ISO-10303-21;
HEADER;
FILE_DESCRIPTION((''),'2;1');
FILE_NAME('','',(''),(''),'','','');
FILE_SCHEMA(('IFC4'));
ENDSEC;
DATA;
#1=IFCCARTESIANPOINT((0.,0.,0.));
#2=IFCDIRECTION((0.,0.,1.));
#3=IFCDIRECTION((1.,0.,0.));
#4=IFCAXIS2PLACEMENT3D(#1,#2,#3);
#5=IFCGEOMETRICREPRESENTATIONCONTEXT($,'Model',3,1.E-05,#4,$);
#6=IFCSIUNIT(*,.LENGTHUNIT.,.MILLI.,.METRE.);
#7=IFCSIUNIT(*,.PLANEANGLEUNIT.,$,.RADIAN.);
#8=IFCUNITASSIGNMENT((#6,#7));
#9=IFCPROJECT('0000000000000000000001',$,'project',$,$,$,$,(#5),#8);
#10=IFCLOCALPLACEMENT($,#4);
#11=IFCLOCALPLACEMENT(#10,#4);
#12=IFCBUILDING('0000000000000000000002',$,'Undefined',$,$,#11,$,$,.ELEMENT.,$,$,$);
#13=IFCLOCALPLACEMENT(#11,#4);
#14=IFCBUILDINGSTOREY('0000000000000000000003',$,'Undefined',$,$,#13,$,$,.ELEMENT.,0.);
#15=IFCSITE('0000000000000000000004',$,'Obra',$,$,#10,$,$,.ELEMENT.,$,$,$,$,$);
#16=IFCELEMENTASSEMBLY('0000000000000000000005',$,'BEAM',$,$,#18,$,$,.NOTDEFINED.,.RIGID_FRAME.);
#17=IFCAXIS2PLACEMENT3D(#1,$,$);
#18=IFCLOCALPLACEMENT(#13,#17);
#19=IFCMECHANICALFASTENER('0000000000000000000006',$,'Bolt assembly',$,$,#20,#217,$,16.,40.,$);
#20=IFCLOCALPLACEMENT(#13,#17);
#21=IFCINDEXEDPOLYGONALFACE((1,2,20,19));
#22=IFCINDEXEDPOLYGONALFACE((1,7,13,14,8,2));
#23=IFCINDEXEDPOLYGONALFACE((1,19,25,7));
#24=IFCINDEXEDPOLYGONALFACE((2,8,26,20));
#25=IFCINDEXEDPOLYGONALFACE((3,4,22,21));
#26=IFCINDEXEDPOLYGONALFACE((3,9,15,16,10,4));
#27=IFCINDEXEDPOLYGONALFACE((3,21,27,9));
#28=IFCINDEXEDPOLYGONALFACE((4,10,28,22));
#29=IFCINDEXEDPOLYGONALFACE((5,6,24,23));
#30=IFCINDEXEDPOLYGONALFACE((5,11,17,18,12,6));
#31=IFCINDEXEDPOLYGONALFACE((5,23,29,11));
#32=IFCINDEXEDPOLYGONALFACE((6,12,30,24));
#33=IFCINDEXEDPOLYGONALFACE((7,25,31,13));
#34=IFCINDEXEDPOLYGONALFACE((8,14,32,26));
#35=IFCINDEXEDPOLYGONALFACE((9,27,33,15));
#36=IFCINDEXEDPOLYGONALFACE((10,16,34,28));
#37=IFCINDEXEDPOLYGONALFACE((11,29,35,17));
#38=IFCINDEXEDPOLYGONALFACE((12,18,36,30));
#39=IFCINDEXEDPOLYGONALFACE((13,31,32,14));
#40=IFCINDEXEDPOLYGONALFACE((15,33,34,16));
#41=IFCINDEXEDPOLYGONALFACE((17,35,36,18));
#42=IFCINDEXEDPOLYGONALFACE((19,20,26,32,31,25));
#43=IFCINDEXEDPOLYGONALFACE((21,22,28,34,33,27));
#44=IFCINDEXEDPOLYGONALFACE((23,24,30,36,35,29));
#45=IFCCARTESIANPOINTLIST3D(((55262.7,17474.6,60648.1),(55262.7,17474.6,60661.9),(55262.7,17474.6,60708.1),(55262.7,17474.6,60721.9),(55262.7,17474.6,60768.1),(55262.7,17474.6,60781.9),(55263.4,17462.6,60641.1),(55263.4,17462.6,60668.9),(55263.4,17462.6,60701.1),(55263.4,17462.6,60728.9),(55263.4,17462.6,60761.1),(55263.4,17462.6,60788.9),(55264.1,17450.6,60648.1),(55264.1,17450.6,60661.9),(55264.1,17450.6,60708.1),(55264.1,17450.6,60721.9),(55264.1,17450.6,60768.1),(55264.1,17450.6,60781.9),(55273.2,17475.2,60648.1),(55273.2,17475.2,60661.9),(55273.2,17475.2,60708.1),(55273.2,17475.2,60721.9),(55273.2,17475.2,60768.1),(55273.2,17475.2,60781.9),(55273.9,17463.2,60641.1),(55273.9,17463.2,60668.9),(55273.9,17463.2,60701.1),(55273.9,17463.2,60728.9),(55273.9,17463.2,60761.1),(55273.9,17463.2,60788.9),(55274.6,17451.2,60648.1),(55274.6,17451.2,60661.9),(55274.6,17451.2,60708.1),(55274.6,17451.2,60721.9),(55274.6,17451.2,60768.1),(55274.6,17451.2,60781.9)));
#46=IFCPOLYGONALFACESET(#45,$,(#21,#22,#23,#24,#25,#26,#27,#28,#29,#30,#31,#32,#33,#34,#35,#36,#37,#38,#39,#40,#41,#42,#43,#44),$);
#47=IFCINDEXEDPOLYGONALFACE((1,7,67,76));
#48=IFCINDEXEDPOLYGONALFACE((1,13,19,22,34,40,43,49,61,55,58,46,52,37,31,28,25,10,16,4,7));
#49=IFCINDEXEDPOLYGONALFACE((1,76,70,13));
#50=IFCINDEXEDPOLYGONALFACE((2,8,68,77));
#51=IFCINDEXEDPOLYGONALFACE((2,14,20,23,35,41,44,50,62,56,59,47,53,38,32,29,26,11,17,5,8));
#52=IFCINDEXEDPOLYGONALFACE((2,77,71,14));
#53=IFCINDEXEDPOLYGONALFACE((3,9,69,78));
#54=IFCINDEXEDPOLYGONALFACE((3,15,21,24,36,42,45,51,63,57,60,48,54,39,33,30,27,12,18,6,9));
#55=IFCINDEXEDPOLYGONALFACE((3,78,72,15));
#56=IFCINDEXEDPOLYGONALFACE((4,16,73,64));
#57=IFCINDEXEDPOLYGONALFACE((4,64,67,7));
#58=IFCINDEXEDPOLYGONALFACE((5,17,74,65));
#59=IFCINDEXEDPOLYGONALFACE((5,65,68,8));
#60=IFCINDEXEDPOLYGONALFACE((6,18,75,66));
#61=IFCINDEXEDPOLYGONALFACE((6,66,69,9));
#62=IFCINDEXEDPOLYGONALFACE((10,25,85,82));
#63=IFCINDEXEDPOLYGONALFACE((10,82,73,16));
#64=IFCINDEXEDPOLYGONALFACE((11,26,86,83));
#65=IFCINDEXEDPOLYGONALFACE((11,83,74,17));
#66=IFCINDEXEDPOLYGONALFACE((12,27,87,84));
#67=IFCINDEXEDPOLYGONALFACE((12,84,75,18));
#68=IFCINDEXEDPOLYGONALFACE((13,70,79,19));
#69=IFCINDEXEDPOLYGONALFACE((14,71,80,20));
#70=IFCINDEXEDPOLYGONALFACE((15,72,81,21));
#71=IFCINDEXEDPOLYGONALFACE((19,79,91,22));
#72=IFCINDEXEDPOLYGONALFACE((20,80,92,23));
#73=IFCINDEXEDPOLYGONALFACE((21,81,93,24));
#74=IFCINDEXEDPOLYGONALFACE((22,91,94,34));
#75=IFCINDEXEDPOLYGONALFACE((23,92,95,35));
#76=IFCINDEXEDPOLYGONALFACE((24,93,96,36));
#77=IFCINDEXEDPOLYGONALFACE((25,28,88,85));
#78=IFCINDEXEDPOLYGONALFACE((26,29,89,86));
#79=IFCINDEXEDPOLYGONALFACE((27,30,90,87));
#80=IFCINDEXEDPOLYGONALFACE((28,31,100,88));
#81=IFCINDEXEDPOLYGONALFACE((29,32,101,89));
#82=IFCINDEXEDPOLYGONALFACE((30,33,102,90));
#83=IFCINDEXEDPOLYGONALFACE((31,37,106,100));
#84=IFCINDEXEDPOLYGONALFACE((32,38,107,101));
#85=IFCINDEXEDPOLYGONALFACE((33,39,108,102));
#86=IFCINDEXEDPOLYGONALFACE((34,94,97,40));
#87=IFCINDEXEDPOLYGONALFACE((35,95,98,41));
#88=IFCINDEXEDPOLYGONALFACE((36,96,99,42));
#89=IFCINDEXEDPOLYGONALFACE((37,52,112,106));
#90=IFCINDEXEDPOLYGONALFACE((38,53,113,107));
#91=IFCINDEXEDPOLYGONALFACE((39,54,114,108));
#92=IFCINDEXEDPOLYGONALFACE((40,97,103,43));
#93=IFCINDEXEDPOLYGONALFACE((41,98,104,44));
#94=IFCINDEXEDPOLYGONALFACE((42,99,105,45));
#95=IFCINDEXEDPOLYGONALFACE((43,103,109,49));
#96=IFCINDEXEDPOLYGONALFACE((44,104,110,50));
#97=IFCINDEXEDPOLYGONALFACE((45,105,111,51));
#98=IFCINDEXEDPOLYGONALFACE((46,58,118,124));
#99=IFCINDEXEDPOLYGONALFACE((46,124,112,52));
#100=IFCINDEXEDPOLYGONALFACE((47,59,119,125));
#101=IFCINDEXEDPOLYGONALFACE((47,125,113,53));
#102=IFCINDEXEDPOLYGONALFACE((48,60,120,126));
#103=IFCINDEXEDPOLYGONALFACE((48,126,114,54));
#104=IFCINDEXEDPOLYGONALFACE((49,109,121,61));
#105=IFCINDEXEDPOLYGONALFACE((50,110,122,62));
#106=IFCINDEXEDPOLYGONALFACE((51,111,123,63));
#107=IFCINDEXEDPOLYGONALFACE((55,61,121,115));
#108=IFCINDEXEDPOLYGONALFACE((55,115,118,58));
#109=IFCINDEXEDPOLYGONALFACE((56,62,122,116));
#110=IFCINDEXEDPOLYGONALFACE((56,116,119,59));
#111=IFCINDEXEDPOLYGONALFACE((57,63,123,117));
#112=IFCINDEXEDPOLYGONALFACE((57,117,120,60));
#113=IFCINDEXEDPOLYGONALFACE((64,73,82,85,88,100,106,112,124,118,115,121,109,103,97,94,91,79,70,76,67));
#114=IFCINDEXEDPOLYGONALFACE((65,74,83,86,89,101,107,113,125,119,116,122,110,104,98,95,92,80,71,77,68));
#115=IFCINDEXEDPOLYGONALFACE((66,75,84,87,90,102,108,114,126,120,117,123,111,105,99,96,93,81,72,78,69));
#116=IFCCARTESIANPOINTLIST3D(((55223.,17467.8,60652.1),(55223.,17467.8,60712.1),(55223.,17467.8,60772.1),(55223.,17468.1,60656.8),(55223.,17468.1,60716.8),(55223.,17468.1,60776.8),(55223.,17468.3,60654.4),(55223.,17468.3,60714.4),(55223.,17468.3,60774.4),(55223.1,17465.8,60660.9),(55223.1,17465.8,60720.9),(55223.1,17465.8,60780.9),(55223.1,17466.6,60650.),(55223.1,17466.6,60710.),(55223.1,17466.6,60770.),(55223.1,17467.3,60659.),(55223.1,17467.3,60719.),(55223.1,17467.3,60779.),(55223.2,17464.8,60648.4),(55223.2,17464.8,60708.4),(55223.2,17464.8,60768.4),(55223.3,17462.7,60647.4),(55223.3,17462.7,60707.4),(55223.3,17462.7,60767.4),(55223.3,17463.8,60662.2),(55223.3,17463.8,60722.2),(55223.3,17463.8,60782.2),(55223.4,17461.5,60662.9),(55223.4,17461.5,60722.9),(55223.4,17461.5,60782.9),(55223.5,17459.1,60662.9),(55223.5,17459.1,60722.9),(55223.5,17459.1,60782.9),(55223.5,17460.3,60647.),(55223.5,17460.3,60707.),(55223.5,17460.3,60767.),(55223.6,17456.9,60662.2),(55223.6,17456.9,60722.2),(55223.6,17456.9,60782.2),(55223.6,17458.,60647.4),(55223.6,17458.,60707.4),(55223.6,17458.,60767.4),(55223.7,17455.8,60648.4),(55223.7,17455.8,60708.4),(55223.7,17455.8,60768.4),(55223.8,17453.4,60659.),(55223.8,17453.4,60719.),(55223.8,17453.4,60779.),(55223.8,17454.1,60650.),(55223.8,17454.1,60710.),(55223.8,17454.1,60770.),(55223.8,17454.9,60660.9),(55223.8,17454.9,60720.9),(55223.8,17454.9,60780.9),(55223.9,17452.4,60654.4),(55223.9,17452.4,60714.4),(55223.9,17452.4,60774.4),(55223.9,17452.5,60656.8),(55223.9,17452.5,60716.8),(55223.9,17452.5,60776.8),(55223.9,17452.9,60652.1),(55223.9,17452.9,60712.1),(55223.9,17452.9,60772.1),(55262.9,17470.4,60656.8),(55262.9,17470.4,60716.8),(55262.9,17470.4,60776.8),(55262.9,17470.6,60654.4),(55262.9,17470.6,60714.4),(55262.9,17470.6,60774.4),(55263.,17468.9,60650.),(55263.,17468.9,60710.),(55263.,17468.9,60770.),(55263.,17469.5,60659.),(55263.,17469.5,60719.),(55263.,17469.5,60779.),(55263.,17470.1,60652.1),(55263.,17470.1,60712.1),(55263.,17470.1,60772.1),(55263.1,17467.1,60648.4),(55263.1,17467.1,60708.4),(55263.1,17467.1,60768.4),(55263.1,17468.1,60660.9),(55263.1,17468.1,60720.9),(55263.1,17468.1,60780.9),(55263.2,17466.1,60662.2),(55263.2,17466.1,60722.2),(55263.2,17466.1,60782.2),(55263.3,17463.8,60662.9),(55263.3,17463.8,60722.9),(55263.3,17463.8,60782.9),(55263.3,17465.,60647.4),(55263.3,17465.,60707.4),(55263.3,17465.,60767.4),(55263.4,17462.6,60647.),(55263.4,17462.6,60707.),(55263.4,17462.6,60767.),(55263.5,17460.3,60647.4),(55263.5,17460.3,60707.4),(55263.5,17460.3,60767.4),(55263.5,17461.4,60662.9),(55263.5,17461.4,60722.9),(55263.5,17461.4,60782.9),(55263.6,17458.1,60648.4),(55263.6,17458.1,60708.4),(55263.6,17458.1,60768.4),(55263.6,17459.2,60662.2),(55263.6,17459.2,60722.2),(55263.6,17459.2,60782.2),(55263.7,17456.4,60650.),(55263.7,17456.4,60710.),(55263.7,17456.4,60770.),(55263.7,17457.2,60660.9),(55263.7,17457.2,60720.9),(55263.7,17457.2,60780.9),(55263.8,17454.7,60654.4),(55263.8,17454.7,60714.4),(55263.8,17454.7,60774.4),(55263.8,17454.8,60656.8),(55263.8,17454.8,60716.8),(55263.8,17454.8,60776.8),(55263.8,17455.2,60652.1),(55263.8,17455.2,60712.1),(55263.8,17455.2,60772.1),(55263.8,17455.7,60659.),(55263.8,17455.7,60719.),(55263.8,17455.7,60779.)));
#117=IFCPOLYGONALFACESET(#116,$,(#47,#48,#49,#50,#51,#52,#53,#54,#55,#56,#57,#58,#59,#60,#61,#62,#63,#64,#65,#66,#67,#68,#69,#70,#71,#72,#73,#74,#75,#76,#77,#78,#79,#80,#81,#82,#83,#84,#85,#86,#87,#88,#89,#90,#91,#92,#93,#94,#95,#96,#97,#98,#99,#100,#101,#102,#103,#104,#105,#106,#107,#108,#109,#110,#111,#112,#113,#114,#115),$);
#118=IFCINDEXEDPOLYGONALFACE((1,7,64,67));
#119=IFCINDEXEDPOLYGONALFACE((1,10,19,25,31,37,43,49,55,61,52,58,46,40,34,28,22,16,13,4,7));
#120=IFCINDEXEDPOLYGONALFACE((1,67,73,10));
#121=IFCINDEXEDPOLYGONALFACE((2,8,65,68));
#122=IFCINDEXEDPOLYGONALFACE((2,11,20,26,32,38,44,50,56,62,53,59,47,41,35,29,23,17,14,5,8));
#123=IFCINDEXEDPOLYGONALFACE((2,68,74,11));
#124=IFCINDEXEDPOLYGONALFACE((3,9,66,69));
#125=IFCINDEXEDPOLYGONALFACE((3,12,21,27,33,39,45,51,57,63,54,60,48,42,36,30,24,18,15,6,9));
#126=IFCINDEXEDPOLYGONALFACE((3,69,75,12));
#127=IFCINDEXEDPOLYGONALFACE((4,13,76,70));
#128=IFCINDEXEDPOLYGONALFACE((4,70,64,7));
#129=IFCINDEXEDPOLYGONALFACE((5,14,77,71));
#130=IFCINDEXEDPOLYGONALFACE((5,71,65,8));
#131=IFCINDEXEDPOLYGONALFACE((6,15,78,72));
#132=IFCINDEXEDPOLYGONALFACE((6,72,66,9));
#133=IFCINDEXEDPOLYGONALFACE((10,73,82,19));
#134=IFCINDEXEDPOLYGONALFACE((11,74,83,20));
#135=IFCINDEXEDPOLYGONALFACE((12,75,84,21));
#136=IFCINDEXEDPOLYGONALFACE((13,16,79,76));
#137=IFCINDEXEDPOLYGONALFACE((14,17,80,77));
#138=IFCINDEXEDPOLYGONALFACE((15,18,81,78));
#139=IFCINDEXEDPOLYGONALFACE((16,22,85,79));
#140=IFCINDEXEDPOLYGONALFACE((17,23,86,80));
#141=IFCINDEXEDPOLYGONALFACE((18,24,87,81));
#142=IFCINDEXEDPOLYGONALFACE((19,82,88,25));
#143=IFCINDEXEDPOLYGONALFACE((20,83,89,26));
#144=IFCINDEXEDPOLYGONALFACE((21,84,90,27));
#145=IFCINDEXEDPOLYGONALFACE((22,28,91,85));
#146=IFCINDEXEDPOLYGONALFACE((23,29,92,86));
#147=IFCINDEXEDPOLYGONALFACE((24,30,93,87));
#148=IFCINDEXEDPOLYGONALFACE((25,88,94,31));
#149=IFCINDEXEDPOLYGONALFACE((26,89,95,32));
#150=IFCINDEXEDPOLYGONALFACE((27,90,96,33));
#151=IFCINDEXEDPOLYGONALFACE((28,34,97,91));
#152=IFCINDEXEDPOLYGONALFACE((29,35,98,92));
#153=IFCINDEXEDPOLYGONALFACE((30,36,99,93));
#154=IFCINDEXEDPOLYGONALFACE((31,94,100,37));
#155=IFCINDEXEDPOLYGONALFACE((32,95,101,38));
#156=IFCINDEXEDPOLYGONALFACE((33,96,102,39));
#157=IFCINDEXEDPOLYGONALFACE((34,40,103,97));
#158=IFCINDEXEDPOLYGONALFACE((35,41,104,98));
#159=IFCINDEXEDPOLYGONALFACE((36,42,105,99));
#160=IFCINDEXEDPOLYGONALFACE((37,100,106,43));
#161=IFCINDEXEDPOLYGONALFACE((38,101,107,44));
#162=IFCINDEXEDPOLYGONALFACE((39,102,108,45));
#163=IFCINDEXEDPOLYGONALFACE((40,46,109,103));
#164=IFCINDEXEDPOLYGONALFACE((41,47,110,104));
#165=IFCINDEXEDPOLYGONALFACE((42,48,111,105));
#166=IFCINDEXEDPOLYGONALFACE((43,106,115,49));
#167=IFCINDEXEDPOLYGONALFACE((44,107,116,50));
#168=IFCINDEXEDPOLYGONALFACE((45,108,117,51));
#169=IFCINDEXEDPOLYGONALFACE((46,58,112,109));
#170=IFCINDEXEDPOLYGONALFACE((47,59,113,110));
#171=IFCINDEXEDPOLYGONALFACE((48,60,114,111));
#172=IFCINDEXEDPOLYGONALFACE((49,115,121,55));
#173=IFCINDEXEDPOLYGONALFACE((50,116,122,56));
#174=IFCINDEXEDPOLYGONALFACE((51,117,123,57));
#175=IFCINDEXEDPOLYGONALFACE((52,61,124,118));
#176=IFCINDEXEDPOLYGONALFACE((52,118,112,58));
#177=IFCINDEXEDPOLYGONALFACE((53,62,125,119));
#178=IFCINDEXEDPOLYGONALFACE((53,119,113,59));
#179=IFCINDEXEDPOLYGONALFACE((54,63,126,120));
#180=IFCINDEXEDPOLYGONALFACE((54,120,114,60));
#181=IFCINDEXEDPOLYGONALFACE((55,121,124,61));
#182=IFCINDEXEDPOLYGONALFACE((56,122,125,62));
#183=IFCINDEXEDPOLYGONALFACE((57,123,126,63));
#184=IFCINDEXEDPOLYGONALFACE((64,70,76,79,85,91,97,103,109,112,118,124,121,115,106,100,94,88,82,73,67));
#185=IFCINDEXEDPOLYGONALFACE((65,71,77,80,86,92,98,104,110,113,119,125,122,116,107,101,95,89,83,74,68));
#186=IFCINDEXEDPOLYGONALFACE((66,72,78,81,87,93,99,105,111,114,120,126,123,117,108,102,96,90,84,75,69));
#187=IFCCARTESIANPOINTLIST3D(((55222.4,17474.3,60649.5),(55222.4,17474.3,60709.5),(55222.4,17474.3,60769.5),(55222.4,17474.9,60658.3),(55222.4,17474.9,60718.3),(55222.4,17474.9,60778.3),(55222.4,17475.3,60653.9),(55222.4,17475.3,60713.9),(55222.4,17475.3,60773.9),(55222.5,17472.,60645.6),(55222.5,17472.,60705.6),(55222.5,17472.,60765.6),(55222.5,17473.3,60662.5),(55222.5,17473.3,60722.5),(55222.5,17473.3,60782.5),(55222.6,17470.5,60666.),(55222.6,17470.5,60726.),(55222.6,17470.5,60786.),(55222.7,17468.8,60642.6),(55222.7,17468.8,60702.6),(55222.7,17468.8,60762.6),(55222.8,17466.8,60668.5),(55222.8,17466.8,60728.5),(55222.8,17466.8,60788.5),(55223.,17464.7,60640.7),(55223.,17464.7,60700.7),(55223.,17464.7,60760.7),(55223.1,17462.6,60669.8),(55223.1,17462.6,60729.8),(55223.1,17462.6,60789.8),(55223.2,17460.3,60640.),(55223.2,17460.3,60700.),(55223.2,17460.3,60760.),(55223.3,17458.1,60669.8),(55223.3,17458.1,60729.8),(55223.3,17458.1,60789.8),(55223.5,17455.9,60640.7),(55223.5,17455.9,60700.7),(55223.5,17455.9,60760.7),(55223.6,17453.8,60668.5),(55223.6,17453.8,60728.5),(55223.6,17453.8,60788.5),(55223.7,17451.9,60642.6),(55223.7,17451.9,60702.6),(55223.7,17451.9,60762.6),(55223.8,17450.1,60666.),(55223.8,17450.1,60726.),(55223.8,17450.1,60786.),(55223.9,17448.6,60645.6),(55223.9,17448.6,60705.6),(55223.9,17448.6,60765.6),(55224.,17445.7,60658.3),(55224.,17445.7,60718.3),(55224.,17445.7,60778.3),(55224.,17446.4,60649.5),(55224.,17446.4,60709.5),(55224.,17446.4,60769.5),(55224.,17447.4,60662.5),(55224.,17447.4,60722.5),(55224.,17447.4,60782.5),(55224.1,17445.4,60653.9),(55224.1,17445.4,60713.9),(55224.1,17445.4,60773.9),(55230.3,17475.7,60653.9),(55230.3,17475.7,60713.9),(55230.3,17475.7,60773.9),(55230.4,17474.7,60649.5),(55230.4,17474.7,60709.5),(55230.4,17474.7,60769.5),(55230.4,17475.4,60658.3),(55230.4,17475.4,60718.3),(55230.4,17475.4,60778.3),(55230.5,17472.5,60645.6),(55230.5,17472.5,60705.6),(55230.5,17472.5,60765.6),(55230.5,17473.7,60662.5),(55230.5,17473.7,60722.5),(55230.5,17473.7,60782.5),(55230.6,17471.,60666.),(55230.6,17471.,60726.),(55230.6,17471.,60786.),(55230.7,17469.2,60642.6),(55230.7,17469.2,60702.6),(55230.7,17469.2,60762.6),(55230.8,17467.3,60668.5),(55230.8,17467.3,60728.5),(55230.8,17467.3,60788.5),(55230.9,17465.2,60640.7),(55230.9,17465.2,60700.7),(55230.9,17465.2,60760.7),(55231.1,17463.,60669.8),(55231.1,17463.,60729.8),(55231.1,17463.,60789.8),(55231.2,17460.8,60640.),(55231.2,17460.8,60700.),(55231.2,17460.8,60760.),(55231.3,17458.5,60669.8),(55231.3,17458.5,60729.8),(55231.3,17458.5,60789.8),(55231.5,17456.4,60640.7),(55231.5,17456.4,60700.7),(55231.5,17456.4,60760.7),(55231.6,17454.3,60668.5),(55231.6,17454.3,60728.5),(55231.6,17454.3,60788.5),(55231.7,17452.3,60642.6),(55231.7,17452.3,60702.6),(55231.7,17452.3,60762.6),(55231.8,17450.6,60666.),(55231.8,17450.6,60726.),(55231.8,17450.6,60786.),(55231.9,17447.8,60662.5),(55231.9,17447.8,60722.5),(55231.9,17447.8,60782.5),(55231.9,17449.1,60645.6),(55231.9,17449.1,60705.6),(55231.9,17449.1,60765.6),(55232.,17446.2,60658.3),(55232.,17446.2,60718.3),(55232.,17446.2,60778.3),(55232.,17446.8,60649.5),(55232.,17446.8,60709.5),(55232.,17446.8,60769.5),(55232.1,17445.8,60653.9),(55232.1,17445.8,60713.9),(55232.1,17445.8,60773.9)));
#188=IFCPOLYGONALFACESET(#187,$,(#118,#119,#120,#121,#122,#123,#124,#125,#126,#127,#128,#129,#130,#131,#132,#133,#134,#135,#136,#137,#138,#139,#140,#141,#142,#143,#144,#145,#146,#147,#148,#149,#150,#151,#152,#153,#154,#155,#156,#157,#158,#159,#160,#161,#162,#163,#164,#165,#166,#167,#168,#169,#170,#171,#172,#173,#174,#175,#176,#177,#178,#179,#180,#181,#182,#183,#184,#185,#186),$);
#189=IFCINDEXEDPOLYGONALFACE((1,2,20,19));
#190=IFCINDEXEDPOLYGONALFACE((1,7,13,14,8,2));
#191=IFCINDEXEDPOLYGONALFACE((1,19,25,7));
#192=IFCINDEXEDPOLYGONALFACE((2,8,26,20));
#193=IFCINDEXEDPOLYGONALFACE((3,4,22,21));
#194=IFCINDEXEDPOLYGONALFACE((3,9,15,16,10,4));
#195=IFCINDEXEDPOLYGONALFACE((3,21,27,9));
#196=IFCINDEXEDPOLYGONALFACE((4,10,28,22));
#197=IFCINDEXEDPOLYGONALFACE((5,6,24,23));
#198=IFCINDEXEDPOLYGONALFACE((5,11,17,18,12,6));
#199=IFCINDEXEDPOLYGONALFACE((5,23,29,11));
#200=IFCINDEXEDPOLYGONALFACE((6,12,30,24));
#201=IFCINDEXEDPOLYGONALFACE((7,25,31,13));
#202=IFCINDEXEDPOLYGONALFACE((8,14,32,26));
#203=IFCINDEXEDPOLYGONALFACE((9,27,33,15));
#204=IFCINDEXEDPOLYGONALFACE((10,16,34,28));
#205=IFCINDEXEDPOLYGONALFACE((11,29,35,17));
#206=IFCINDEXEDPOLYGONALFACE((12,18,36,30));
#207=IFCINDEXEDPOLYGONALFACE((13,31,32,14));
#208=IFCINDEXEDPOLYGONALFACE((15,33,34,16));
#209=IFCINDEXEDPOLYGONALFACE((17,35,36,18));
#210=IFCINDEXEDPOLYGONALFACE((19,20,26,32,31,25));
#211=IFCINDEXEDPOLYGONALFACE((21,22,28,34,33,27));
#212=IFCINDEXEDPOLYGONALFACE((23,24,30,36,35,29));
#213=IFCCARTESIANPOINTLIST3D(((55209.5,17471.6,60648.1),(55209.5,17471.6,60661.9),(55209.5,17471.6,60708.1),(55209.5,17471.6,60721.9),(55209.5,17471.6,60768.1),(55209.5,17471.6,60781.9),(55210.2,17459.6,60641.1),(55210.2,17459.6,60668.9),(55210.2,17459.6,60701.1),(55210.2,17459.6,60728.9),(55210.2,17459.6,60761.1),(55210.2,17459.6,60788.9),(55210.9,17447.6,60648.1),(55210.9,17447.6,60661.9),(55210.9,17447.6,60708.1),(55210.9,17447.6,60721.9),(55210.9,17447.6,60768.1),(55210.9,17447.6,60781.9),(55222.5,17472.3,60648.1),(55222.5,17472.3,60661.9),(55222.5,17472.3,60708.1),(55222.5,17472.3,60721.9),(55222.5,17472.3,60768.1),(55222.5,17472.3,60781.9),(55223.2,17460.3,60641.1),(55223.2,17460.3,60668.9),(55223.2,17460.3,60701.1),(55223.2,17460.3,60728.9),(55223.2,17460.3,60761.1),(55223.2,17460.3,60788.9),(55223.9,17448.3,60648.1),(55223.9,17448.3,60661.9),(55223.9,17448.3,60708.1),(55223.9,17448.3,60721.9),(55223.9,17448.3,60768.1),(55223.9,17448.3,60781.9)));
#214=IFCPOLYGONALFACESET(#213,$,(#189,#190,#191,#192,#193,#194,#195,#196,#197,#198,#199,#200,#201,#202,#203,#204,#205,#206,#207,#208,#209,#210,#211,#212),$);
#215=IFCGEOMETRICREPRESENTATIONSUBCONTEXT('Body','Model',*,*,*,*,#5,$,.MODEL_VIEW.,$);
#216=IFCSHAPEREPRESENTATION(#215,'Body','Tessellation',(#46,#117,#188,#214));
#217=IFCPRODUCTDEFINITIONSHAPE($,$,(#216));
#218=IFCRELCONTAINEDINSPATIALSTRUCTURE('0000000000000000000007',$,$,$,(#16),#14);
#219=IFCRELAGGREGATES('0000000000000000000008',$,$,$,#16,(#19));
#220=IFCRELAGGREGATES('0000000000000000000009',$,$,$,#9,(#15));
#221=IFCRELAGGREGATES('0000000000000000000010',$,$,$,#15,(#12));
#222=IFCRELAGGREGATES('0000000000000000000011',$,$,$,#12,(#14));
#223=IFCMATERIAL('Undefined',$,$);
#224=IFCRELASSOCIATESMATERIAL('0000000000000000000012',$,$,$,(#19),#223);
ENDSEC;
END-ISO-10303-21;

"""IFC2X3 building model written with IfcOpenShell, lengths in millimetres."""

from ifc_helpers import new_model, si_unit, frame, origin_with_axes, origin_2d_with_axis, place, context, subcontext, project, spatial, polyline, circle, outline, extrude, source, transform, mapped, material, element, aggregate, save


model = new_model("IFC2X3")

# Units and contexts
model_context = context("Model", 3, precision=1e-05, world=origin_with_axes())
body_context = subcontext(model_context, "Body", "Model", "MODEL_VIEW")
ifc_project = project(units=[si_unit("LENGTHUNIT", "METRE", prefix="MILLI"), si_unit("PLANEANGLEUNIT", "RADIAN")], contexts=[model_context])

# Site, building, storey
site_placement = place(None, origin_with_axes())
site = spatial("IfcSite", under=ifc_project, at=site_placement, Name="Obra", CompositionType="ELEMENT")
building_placement = place(site_placement, origin_with_axes())
building = spatial("IfcBuilding", under=site, at=building_placement, Name="Undefined", CompositionType="ELEMENT")
storey_placement = place(building_placement, origin_with_axes())
storey = spatial("IfcBuildingStorey", under=building, at=storey_placement, Name="Undefined", CompositionType="ELEMENT", Elevation=0.0)

# Element assembly, mechanical fastener
ifc_material_1 = material(Name="Undefined")
shared_shape_1 = source(origin_with_axes(), body_context, "Body", "SweptSolid", [
    extrude(outline(polyline([(13.9, 0.0), (6.9, 12.0), (-6.9, 12.0), (-13.9, 0.0), (-6.9, -12.0), (6.9, -12.0), (13.9, 0.0)])), frame((0.0, -45.9, 0.0), z_axis=(0.0, 1.0, 0.0), x_axis=(1.0, 0.0, 0.0)), (0.0, 0.0, 1.0), 10.6),
    extrude(circle(Radius=8.0, at=origin_2d_with_axis()), frame((0.0, -35.3, 0.0), z_axis=(0.0, 1.0, 0.0), x_axis=(1.0, 0.0, 0.0)), (0.0, 0.0, 1.0), 40.0),
    extrude(circle(Radius=15.0, at=origin_2d_with_axis()), frame((0.0, -3.1, 0.0), z_axis=(0.0, 1.0, 0.0), x_axis=(1.0, 0.0, 0.0)), (0.0, 0.0, 1.0), 8.0),
    extrude(outline(polyline([(13.9, 0.0), (6.9, 12.0), (-6.9, 12.0), (-13.9, 0.0), (-6.9, -12.0), (6.9, -12.0), (13.9, 0.0)])), frame((0.0, 4.9, 0.0), z_axis=(0.0, 1.0, 0.0), x_axis=(1.0, 0.0, 0.0)), (0.0, 0.0, 1.0), 13.0),
])
assembly_1_placement = place(storey_placement, origin_with_axes())
assembly_1 = element("IfcElementAssembly", 1, at=assembly_1_placement, inside=storey, Name="BEAM", AssemblyPlace="NOTDEFINED", PredefinedType="RIGID_FRAME")
mechanical_fastener_1_placement = place(assembly_1_placement, frame((55231.0, 17410.7, 60835.0), z_axis=(-0.057107, 0.998368, 0.0), x_axis=(0.0, 0.0, -1.0)))
mechanical_fastener_1 = element("IfcMechanicalFastener", 2, at=mechanical_fastener_1_placement, material=ifc_material_1, Name="Bolt assembly", NominalDiameter=16.0, NominalLength=40.0, context=body_context, shape_type="MappedRepresentation", body=[
    mapped(shared_shape_1, transform((60.0, 0.0, 50.0))),
    mapped(shared_shape_1, transform((120.0, 0.0, 50.0))),
    mapped(shared_shape_1, transform((180.0, 0.0, 50.0))),
])
aggregate(assembly_1, [mechanical_fastener_1])

save(model, "model.ifc")
